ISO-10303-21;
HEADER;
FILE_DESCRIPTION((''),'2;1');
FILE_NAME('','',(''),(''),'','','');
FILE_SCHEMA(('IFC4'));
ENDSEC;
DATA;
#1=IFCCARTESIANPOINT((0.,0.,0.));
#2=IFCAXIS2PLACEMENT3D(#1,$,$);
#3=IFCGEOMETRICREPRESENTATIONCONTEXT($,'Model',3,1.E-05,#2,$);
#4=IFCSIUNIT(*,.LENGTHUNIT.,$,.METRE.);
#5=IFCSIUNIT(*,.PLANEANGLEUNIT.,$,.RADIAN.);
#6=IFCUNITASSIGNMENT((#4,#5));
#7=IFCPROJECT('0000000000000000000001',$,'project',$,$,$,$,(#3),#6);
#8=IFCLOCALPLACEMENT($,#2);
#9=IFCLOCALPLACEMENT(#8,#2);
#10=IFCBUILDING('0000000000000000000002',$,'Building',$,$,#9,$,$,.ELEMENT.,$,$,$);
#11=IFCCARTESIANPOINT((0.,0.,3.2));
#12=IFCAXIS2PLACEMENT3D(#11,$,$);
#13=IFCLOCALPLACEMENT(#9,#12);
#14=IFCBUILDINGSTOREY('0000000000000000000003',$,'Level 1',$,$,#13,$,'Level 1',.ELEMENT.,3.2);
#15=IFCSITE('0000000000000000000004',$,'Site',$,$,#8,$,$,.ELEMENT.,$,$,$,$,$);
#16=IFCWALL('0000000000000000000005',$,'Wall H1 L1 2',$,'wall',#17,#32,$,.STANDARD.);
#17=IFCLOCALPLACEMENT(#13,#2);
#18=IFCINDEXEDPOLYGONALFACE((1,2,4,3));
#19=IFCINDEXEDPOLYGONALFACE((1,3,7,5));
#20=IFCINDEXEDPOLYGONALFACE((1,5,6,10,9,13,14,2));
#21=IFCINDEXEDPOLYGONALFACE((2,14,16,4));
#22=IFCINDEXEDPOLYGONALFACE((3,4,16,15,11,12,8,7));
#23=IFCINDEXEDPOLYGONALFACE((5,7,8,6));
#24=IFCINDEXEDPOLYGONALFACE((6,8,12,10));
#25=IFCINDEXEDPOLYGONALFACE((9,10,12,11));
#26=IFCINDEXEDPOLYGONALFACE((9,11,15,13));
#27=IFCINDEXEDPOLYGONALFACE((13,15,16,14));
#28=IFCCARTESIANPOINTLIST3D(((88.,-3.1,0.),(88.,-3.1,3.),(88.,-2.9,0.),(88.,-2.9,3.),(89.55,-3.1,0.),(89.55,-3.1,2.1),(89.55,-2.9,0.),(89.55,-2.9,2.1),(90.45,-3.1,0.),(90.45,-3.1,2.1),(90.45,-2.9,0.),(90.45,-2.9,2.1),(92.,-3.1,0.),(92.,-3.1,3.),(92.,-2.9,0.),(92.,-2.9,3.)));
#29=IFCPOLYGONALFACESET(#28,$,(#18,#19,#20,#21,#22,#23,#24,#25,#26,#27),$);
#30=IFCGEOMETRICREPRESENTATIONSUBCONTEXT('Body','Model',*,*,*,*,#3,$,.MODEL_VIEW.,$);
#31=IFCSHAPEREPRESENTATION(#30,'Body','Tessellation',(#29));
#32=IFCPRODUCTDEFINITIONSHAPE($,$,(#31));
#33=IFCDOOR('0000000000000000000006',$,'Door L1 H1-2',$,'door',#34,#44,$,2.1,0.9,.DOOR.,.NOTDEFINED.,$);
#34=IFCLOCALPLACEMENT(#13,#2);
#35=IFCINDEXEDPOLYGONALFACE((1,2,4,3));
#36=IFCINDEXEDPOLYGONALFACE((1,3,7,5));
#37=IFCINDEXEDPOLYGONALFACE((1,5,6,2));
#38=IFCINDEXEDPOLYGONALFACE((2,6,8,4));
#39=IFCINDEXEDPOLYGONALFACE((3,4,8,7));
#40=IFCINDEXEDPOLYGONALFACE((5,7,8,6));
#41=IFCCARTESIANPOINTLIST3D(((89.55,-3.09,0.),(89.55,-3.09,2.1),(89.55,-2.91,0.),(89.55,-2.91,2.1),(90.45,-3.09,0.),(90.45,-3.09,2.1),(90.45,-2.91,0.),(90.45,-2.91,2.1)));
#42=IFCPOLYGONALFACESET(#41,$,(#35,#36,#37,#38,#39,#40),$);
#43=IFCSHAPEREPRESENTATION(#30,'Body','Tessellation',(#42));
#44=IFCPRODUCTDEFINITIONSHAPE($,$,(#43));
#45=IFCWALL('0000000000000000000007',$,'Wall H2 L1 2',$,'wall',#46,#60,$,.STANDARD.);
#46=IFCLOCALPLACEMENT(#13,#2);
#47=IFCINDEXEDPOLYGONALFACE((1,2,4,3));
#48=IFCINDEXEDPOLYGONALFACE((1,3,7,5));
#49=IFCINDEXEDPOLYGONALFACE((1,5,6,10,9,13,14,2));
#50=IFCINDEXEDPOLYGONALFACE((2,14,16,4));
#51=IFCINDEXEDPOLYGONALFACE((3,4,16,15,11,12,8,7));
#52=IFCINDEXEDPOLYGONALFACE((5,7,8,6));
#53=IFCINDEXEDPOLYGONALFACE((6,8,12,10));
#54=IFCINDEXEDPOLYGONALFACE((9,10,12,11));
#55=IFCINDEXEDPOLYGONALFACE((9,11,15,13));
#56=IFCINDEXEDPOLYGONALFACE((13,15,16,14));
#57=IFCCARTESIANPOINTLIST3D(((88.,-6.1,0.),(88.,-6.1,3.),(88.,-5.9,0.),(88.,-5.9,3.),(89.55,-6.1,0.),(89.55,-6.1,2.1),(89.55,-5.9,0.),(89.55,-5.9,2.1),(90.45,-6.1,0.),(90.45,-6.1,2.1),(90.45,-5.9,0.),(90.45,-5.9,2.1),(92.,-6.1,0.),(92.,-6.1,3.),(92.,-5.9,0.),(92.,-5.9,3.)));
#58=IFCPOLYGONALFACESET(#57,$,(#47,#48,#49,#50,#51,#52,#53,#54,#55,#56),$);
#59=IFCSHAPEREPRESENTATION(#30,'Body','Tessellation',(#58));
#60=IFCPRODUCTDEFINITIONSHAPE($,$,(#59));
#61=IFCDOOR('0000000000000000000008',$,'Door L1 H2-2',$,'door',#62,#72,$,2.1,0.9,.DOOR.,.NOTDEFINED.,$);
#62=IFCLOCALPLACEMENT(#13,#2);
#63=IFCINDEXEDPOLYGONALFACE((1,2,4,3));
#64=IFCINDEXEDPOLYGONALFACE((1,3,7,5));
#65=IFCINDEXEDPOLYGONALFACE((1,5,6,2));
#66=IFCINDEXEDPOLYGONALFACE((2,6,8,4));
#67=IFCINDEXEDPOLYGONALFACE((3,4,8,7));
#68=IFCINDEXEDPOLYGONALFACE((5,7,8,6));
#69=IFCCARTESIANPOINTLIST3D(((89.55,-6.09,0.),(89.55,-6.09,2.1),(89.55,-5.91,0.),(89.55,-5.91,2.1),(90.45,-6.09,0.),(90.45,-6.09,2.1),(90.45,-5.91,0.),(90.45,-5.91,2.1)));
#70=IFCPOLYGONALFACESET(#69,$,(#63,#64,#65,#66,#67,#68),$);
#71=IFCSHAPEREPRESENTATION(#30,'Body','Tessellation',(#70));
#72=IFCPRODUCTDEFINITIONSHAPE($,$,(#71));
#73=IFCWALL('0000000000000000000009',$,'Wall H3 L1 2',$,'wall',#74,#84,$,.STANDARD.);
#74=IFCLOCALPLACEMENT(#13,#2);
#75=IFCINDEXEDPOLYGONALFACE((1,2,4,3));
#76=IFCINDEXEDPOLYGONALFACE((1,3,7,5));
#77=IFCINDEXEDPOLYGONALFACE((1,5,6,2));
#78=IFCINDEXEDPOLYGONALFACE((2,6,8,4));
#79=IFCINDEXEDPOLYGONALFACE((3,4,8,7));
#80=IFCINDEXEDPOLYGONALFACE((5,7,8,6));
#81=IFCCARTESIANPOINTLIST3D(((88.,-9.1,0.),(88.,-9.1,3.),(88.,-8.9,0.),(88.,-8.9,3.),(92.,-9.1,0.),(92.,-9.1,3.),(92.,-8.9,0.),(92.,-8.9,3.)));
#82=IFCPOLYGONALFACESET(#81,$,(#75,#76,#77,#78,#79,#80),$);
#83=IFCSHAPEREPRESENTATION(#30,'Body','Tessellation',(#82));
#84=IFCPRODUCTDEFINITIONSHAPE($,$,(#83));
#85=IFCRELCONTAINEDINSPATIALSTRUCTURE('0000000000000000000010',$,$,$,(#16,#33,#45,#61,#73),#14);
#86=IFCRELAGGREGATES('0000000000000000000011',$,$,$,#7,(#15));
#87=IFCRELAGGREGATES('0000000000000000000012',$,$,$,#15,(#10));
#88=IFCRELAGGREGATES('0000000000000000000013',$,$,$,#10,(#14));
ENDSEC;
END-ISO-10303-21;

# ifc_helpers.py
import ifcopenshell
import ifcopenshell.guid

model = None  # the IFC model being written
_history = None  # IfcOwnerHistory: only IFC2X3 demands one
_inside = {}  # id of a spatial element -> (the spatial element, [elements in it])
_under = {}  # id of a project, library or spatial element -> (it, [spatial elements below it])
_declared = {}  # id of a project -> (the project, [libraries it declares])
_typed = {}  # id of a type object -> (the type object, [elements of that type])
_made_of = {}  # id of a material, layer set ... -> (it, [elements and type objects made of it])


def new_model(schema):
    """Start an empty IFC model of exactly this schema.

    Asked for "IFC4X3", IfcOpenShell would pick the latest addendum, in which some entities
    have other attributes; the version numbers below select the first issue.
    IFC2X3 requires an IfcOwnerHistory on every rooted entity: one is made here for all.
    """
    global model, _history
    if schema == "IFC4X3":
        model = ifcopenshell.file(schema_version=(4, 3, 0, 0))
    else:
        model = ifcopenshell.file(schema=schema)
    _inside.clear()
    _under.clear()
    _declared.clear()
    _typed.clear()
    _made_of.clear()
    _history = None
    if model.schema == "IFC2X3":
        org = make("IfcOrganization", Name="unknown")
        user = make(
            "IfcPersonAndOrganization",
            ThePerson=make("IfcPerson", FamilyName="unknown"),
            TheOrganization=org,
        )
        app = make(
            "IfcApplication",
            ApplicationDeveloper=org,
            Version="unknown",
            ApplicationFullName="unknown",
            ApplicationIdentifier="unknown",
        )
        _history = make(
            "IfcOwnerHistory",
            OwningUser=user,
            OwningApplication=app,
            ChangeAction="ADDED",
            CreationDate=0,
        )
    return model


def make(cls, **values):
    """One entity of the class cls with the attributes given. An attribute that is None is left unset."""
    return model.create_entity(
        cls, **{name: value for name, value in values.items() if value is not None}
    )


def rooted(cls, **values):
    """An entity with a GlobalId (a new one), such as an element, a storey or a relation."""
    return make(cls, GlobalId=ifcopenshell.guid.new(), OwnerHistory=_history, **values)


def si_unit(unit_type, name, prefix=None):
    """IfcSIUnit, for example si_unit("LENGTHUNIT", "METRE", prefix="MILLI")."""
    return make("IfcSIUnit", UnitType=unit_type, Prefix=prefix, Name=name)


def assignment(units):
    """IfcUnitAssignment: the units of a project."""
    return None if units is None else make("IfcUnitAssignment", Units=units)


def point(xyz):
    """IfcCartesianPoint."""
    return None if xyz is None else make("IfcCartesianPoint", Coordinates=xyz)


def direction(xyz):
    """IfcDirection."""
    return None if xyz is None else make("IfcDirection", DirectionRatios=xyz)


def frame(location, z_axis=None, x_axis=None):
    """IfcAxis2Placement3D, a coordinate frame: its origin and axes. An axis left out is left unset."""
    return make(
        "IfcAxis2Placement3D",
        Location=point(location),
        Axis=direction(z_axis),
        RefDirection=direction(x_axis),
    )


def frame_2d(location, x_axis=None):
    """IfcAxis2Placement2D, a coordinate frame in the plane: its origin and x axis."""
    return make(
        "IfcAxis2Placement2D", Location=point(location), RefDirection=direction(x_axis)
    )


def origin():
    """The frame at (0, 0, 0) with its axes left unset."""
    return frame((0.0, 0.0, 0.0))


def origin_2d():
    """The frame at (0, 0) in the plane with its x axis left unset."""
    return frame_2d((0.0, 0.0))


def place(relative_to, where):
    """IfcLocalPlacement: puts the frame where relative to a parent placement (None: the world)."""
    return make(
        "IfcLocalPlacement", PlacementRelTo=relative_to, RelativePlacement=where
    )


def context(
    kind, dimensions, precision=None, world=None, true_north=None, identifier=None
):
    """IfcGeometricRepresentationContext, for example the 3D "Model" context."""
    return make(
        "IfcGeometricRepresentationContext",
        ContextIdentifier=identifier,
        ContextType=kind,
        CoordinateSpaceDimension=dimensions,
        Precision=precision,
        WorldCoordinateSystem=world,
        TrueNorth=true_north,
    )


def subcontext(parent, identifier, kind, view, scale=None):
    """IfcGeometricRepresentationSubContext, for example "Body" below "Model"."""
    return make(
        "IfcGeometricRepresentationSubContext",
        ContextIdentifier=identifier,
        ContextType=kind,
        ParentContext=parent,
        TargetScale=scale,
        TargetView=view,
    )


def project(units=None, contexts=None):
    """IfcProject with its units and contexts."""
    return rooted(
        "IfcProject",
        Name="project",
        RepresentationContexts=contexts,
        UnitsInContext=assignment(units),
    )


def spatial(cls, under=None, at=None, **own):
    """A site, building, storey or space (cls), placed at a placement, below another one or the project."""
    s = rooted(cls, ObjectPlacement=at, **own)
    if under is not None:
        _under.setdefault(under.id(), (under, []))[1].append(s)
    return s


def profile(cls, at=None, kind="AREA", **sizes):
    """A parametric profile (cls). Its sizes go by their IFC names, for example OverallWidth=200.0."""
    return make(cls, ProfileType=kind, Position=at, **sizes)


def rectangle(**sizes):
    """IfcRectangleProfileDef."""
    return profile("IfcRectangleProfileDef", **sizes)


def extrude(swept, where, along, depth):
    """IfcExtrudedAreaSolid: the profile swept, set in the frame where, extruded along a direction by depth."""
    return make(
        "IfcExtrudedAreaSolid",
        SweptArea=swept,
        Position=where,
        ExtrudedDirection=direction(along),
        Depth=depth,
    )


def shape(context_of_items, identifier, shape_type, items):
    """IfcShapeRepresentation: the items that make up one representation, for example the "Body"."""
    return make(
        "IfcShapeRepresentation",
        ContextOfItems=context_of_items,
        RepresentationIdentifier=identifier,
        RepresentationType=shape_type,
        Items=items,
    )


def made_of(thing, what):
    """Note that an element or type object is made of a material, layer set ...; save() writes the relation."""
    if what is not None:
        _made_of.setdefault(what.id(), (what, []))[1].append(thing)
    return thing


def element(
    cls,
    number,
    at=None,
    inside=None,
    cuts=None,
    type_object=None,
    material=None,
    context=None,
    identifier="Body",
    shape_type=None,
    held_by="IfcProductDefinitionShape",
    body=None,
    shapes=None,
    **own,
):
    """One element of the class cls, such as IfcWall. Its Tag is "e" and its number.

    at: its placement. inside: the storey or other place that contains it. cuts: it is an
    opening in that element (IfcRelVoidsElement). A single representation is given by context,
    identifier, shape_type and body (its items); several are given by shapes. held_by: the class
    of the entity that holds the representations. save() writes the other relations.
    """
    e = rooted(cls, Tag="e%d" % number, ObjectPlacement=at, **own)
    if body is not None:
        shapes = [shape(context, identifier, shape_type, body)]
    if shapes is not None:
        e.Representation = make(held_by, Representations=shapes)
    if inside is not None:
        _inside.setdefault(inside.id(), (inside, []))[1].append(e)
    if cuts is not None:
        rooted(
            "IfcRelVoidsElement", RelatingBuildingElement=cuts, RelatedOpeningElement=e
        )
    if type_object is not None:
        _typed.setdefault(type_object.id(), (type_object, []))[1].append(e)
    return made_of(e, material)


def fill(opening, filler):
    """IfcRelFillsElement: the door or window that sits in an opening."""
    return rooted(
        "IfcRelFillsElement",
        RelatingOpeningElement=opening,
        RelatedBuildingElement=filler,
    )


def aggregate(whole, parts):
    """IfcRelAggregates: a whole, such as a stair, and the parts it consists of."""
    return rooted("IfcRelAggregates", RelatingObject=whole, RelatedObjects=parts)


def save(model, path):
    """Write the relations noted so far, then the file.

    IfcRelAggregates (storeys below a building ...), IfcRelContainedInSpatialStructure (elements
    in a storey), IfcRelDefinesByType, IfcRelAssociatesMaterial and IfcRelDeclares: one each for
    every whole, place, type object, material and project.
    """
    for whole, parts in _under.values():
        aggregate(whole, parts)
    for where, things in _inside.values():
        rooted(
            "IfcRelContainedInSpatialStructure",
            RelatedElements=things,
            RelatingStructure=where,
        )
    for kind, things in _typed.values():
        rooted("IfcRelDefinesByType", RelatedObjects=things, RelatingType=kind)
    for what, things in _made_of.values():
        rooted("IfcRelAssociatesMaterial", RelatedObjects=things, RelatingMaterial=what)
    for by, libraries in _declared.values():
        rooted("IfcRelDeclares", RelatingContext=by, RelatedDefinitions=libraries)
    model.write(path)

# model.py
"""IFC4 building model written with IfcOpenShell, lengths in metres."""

from ifc_helpers import new_model, si_unit, frame, frame_2d, origin, origin_2d, place, context, subcontext, project, spatial, rectangle, extrude, element, fill, save


model = new_model("IFC4")

# Units and contexts
model_context = context("Model", 3, precision=1e-05, world=origin())
body_context = subcontext(model_context, "Body", "Model", "MODEL_VIEW")
ifc_project = project(units=[si_unit("LENGTHUNIT", "METRE"), si_unit("PLANEANGLEUNIT", "RADIAN")], contexts=[model_context])

# Site, building, storey
site_placement = place(None, origin())
site = spatial("IfcSite", under=ifc_project, at=site_placement, Name="Site", CompositionType="ELEMENT")
building_placement = place(site_placement, origin())
building = spatial("IfcBuilding", under=site, at=building_placement, Name="Building", CompositionType="ELEMENT")
storey_placement = place(building_placement, frame((0.0, 0.0, 3.2)))
storey = spatial("IfcBuildingStorey", under=building, at=storey_placement, Name="Level 1", LongName="Level 1", CompositionType="ELEMENT", Elevation=3.2)

# Walls, openings, doors
wall_1_placement = place(storey_placement, frame((88.0, -3.0, 0.0), z_axis=(0.0, 0.0, 1.0), x_axis=(1.0, 0.0, 0.0)))
wall_1 = element("IfcWall", 1, at=wall_1_placement, inside=storey, Name="Wall H1 L1 2", ObjectType="wall", PredefinedType="STANDARD", context=body_context, shape_type="SweptSolid", body=[
    extrude(rectangle(XDim=4.0, YDim=0.2, at=frame_2d((2.0, 0.0))), origin(), (0.0, 0.0, 1.0), 3.0),
])
opening_1_placement = place(storey_placement, frame((90.0, -3.0, 0.0), z_axis=(0.0, 0.0, 1.0), x_axis=(1.0, 0.0, 0.0)))
opening_1 = element("IfcOpeningElement", 2, at=opening_1_placement, cuts=wall_1, ObjectType="Opening", PredefinedType="OPENING", context=body_context, shape_type="SweptSolid", body=[
    extrude(rectangle(XDim=0.9, YDim=0.22, at=origin_2d()), origin(), (0.0, 0.0, 1.0), 2.1),
])
door_1_placement = place(storey_placement, frame((90.0, -3.0, 0.0), z_axis=(0.0, 0.0, 1.0), x_axis=(1.0, 0.0, 0.0)))
door_1 = element("IfcDoor", 3, at=door_1_placement, inside=storey, Name="Door L1 H1-2", ObjectType="door", OperationType="NOTDEFINED", OverallHeight=2.1, OverallWidth=0.9, PredefinedType="DOOR", context=body_context, shape_type="SweptSolid", body=[
    extrude(rectangle(XDim=0.9, YDim=0.18, at=origin_2d()), origin(), (0.0, 0.0, 1.0), 2.1),
])
fill(opening_1, door_1)
wall_2_placement = place(storey_placement, frame((88.0, -6.0, 0.0), z_axis=(0.0, 0.0, 1.0), x_axis=(1.0, 0.0, 0.0)))
wall_2 = element("IfcWall", 4, at=wall_2_placement, inside=storey, Name="Wall H2 L1 2", ObjectType="wall", PredefinedType="STANDARD", context=body_context, shape_type="SweptSolid", body=[
    extrude(rectangle(XDim=4.0, YDim=0.2, at=frame_2d((2.0, 0.0))), origin(), (0.0, 0.0, 1.0), 3.0),
])
opening_2_placement = place(storey_placement, frame((90.0, -6.0, 0.0), z_axis=(0.0, 0.0, 1.0), x_axis=(1.0, 0.0, 0.0)))
opening_2 = element("IfcOpeningElement", 5, at=opening_2_placement, cuts=wall_2, ObjectType="Opening", PredefinedType="OPENING", context=body_context, shape_type="SweptSolid", body=[
    extrude(rectangle(XDim=0.9, YDim=0.22, at=origin_2d()), origin(), (0.0, 0.0, 1.0), 2.1),
])
door_2_placement = place(storey_placement, frame((90.0, -6.0, 0.0), z_axis=(0.0, 0.0, 1.0), x_axis=(1.0, 0.0, 0.0)))
door_2 = element("IfcDoor", 6, at=door_2_placement, inside=storey, Name="Door L1 H2-2", ObjectType="door", OperationType="NOTDEFINED", OverallHeight=2.1, OverallWidth=0.9, PredefinedType="DOOR", context=body_context, shape_type="SweptSolid", body=[
    extrude(rectangle(XDim=0.9, YDim=0.18, at=origin_2d()), origin(), (0.0, 0.0, 1.0), 2.1),
])
fill(opening_2, door_2)

# Wall
wall_3_placement = place(storey_placement, frame((88.0, -9.0, 0.0), z_axis=(0.0, 0.0, 1.0), x_axis=(1.0, 0.0, 0.0)))
element("IfcWall", 7, at=wall_3_placement, inside=storey, Name="Wall H3 L1 2", ObjectType="wall", PredefinedType="STANDARD", context=body_context, shape_type="SweptSolid", body=[
    extrude(rectangle(XDim=4.0, YDim=0.2, at=frame_2d((2.0, 0.0))), origin(), (0.0, 0.0, 1.0), 3.0),
])

save(model, "model.ifc")
